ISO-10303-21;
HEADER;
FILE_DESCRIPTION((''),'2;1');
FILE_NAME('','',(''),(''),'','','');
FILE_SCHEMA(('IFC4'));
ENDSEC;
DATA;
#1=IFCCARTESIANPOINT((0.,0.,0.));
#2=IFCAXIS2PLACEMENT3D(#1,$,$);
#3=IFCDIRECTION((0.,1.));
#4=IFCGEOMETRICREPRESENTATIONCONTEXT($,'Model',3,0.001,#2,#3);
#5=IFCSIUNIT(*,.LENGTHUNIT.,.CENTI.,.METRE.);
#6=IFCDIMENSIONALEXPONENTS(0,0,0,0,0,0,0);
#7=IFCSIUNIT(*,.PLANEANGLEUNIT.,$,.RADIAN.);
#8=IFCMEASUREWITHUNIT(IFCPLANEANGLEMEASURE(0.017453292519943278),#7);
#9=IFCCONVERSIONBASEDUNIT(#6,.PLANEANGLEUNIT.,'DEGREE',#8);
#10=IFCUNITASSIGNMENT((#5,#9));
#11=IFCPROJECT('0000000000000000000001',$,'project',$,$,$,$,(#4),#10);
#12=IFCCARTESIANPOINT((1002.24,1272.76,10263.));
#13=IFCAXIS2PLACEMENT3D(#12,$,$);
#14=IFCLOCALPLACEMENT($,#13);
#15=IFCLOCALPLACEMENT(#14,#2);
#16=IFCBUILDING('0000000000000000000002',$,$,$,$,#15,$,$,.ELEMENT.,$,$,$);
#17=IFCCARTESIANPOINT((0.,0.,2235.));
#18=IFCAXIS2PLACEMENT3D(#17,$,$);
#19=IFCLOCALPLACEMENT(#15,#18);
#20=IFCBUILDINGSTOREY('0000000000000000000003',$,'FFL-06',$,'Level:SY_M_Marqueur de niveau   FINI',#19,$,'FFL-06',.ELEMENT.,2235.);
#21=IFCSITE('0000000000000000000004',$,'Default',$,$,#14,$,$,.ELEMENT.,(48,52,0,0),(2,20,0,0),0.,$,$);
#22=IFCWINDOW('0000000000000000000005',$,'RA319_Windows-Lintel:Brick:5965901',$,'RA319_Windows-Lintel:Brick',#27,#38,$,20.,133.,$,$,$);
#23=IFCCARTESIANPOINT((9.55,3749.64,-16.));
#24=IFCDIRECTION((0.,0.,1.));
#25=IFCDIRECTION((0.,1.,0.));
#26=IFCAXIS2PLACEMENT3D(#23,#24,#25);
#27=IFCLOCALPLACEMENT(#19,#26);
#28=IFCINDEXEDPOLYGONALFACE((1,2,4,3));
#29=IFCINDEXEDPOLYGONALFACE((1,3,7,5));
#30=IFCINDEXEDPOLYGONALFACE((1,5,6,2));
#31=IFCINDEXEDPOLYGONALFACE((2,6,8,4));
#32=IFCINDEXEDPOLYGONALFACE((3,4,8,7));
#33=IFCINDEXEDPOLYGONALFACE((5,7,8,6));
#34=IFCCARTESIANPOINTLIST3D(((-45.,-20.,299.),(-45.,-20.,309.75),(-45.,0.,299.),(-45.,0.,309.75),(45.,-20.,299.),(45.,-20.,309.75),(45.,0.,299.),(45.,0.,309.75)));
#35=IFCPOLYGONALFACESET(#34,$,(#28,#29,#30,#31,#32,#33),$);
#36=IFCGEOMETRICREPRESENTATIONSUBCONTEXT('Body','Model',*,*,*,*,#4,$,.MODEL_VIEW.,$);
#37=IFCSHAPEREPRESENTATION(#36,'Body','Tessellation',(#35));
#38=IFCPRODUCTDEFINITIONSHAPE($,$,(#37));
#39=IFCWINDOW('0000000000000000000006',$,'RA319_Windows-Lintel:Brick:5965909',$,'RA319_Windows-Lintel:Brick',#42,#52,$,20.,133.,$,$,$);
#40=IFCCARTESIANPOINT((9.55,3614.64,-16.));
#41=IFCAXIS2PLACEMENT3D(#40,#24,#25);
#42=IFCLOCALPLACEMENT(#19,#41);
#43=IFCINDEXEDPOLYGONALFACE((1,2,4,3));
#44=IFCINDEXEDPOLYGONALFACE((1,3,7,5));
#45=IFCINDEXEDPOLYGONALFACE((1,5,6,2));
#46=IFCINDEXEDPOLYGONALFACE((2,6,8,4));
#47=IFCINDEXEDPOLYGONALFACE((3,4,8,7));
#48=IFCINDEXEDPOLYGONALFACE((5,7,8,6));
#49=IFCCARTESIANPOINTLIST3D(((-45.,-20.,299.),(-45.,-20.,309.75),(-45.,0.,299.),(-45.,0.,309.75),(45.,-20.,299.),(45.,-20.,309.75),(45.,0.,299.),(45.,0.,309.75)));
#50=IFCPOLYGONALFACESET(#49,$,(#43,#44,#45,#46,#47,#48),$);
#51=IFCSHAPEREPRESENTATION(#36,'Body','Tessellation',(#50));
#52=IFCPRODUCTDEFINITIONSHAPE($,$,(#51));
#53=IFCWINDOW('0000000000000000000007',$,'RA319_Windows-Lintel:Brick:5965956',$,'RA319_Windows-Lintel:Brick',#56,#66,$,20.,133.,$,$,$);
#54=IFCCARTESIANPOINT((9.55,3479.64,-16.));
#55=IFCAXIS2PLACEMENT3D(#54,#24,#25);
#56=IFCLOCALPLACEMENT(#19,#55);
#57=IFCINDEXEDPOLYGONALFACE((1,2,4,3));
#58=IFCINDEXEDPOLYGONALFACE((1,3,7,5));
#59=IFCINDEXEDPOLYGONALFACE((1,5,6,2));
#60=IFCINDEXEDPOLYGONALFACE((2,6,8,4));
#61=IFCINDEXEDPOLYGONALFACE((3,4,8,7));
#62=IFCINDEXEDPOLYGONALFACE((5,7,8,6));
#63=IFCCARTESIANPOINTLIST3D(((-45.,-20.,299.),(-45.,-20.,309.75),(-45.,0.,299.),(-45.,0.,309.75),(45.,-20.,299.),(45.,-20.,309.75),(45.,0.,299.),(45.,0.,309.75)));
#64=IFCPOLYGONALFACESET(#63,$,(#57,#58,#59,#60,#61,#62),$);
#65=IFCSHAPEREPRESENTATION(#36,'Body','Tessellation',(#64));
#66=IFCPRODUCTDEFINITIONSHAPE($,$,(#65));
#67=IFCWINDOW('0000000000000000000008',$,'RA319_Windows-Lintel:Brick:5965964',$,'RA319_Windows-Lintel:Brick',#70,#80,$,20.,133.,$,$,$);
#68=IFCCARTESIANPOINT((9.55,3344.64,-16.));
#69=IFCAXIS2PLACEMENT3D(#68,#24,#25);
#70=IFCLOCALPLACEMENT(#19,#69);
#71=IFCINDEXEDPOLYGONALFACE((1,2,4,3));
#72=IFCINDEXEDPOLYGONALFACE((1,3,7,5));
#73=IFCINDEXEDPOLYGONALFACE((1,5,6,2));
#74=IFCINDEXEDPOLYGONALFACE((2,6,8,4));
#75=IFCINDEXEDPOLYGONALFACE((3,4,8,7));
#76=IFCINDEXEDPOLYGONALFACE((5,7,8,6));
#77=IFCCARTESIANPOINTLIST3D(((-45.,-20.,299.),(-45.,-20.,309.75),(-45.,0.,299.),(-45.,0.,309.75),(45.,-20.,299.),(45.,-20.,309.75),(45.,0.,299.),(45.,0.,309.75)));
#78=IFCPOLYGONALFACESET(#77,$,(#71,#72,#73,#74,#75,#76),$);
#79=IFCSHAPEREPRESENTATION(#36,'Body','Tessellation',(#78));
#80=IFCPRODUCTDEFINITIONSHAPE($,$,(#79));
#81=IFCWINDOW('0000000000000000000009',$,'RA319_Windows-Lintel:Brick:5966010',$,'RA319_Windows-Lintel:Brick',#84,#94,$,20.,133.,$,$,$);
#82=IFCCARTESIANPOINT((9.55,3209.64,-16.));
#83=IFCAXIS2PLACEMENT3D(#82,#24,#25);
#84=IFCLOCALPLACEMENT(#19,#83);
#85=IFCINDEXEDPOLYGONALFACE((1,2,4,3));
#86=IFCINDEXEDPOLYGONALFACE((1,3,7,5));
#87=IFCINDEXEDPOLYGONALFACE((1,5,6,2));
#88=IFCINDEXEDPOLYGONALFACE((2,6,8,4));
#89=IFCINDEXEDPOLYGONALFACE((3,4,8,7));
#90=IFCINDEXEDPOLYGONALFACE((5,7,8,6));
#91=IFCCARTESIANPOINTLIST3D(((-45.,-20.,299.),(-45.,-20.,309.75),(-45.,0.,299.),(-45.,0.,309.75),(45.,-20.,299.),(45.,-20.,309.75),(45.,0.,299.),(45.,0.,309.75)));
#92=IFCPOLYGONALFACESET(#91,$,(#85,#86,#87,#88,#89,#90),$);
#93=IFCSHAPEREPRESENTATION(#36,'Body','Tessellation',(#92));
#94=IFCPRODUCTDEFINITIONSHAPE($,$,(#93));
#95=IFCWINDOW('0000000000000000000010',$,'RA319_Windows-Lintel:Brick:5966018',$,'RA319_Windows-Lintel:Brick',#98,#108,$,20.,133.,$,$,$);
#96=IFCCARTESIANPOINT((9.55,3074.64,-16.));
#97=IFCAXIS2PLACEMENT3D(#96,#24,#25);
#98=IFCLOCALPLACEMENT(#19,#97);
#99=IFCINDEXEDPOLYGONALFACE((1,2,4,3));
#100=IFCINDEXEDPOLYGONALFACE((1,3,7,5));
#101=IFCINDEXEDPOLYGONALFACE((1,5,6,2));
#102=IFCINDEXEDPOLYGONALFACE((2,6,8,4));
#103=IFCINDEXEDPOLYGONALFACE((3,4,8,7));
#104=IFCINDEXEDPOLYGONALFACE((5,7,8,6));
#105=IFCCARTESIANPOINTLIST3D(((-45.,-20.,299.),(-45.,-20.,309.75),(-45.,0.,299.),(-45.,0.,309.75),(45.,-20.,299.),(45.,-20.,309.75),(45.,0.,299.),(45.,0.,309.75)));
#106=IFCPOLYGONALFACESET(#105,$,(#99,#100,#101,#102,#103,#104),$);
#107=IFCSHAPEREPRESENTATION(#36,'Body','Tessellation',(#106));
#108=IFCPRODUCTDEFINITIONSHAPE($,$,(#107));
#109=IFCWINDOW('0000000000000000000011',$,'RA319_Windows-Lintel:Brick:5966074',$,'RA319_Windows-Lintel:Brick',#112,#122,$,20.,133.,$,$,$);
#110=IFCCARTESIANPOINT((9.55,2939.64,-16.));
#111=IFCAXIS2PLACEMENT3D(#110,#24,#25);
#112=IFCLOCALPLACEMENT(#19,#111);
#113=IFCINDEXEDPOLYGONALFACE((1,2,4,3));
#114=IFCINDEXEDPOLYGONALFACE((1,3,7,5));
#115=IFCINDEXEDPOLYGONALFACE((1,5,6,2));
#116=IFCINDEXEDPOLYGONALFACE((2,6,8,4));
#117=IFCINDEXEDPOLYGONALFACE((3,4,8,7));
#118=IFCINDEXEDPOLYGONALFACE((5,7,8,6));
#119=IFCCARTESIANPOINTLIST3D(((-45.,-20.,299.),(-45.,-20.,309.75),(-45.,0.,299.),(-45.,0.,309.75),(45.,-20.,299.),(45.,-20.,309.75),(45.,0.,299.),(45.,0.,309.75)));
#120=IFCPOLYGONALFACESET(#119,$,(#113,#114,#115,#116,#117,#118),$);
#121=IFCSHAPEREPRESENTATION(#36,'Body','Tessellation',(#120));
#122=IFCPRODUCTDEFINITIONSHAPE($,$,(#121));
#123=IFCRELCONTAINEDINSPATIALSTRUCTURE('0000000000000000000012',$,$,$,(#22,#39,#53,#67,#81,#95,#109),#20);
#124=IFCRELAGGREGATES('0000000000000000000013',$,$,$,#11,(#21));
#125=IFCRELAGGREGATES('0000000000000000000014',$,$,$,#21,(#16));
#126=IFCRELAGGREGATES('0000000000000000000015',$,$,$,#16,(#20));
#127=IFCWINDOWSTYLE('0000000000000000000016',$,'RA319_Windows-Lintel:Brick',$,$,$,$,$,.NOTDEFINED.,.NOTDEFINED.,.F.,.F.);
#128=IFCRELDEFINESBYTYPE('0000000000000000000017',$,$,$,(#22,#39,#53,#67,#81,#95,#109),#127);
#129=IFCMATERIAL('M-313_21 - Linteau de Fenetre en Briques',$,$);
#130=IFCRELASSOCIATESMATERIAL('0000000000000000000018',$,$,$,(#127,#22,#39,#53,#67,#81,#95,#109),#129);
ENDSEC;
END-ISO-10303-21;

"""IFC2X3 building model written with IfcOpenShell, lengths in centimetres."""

from ifc_helpers import new_model, entity, si_unit, converted_unit, direction, frame, origin, origin_2d_with_axis, place, context, subcontext, project, spatial, rectangle, extrude, source, transform, mapped, material, type_object, type_shapes, element, save


model = new_model("IFC2X3")

# Units and contexts
model_context = context("Model", 3, precision=0.001, world=origin(), true_north=direction((0.0, 1.0)))
body_context = subcontext(model_context, "Body", "Model", "MODEL_VIEW")
ifc_project = project(units=[si_unit("LENGTHUNIT", "METRE", prefix="CENTI"), converted_unit("PLANEANGLEUNIT", "DEGREE", entity("IfcPlaneAngleMeasure", 0.017453292519943278), si_unit("PLANEANGLEUNIT", "RADIAN"), dimensions=[0, 0, 0, 0, 0, 0, 0])], contexts=[model_context])

# Site, building, storey
site_placement = place(None, frame((1002.24, 1272.76, 10263.0)))
site = spatial("IfcSite", under=ifc_project, at=site_placement, Name="Default", CompositionType="ELEMENT", RefLatitude=(48, 52, 0, 0), RefLongitude=(2, 20, 0, 0), RefElevation=0.0)
building_placement = place(site_placement, origin())
building = spatial("IfcBuilding", under=site, at=building_placement, CompositionType="ELEMENT")
storey_placement = place(building_placement, frame((0.0, 0.0, 2235.0)))
storey = spatial("IfcBuildingStorey", under=building, at=storey_placement, Name="FFL-06", ObjectType="Level:SY_M_Marqueur de niveau   FINI", LongName="FFL-06", CompositionType="ELEMENT", Elevation=2235.0)

# Windows
ifc_material_1 = material(Name="M-313_21 - Linteau de Fenetre en Briques")
window_style_1 = type_object("IfcWindowStyle", Name="RA319_Windows-Lintel:Brick", ConstructionType="NOTDEFINED", OperationType="NOTDEFINED", ParameterTakesPrecedence=False, Sizeable=False, material=ifc_material_1)
shared_shape_1 = source(origin(), body_context, "Body", "SweptSolid", [
    extrude(rectangle(XDim=90.0, YDim=20.0, at=origin_2d_with_axis()), frame((0.0, -10.0, 299.0)), (0.0, 0.0, 1.0), 10.75),
])
type_shapes(window_style_1, [shared_shape_1])
for number, where, z_axis, x_axis, name in (
    (1, (9.55, 3749.64, -16.0), (0.0, 0.0, 1.0), (0.0, 1.0, 0.0), "RA319_Windows-Lintel:Brick:5965901"),
    (2, (9.55, 3614.64, -16.0), (0.0, 0.0, 1.0), (0.0, 1.0, 0.0), "RA319_Windows-Lintel:Brick:5965909"),
    (3, (9.55, 3479.64, -16.0), (0.0, 0.0, 1.0), (0.0, 1.0, 0.0), "RA319_Windows-Lintel:Brick:5965956"),
    (4, (9.55, 3344.64, -16.0), (0.0, 0.0, 1.0), (0.0, 1.0, 0.0), "RA319_Windows-Lintel:Brick:5965964"),
    (5, (9.55, 3209.64, -16.0), (0.0, 0.0, 1.0), (0.0, 1.0, 0.0), "RA319_Windows-Lintel:Brick:5966010"),
    (6, (9.55, 3074.64, -16.0), (0.0, 0.0, 1.0), (0.0, 1.0, 0.0), "RA319_Windows-Lintel:Brick:5966018"),
    (7, (9.55, 2939.64, -16.0), (0.0, 0.0, 1.0), (0.0, 1.0, 0.0), "RA319_Windows-Lintel:Brick:5966074"),
):
    element("IfcWindow", number, at=place(storey_placement, frame(where, z_axis=z_axis, x_axis=x_axis)), inside=storey, type_object=window_style_1, material=ifc_material_1, Name=name, ObjectType="RA319_Windows-Lintel:Brick", OverallHeight=20.0, OverallWidth=133.0, context=body_context, shape_type="MappedRepresentation", body=[
        mapped(shared_shape_1, transform((0.0, 0.0, 0.0), scale=1.0)),
    ])

save(model, "model.ifc")
